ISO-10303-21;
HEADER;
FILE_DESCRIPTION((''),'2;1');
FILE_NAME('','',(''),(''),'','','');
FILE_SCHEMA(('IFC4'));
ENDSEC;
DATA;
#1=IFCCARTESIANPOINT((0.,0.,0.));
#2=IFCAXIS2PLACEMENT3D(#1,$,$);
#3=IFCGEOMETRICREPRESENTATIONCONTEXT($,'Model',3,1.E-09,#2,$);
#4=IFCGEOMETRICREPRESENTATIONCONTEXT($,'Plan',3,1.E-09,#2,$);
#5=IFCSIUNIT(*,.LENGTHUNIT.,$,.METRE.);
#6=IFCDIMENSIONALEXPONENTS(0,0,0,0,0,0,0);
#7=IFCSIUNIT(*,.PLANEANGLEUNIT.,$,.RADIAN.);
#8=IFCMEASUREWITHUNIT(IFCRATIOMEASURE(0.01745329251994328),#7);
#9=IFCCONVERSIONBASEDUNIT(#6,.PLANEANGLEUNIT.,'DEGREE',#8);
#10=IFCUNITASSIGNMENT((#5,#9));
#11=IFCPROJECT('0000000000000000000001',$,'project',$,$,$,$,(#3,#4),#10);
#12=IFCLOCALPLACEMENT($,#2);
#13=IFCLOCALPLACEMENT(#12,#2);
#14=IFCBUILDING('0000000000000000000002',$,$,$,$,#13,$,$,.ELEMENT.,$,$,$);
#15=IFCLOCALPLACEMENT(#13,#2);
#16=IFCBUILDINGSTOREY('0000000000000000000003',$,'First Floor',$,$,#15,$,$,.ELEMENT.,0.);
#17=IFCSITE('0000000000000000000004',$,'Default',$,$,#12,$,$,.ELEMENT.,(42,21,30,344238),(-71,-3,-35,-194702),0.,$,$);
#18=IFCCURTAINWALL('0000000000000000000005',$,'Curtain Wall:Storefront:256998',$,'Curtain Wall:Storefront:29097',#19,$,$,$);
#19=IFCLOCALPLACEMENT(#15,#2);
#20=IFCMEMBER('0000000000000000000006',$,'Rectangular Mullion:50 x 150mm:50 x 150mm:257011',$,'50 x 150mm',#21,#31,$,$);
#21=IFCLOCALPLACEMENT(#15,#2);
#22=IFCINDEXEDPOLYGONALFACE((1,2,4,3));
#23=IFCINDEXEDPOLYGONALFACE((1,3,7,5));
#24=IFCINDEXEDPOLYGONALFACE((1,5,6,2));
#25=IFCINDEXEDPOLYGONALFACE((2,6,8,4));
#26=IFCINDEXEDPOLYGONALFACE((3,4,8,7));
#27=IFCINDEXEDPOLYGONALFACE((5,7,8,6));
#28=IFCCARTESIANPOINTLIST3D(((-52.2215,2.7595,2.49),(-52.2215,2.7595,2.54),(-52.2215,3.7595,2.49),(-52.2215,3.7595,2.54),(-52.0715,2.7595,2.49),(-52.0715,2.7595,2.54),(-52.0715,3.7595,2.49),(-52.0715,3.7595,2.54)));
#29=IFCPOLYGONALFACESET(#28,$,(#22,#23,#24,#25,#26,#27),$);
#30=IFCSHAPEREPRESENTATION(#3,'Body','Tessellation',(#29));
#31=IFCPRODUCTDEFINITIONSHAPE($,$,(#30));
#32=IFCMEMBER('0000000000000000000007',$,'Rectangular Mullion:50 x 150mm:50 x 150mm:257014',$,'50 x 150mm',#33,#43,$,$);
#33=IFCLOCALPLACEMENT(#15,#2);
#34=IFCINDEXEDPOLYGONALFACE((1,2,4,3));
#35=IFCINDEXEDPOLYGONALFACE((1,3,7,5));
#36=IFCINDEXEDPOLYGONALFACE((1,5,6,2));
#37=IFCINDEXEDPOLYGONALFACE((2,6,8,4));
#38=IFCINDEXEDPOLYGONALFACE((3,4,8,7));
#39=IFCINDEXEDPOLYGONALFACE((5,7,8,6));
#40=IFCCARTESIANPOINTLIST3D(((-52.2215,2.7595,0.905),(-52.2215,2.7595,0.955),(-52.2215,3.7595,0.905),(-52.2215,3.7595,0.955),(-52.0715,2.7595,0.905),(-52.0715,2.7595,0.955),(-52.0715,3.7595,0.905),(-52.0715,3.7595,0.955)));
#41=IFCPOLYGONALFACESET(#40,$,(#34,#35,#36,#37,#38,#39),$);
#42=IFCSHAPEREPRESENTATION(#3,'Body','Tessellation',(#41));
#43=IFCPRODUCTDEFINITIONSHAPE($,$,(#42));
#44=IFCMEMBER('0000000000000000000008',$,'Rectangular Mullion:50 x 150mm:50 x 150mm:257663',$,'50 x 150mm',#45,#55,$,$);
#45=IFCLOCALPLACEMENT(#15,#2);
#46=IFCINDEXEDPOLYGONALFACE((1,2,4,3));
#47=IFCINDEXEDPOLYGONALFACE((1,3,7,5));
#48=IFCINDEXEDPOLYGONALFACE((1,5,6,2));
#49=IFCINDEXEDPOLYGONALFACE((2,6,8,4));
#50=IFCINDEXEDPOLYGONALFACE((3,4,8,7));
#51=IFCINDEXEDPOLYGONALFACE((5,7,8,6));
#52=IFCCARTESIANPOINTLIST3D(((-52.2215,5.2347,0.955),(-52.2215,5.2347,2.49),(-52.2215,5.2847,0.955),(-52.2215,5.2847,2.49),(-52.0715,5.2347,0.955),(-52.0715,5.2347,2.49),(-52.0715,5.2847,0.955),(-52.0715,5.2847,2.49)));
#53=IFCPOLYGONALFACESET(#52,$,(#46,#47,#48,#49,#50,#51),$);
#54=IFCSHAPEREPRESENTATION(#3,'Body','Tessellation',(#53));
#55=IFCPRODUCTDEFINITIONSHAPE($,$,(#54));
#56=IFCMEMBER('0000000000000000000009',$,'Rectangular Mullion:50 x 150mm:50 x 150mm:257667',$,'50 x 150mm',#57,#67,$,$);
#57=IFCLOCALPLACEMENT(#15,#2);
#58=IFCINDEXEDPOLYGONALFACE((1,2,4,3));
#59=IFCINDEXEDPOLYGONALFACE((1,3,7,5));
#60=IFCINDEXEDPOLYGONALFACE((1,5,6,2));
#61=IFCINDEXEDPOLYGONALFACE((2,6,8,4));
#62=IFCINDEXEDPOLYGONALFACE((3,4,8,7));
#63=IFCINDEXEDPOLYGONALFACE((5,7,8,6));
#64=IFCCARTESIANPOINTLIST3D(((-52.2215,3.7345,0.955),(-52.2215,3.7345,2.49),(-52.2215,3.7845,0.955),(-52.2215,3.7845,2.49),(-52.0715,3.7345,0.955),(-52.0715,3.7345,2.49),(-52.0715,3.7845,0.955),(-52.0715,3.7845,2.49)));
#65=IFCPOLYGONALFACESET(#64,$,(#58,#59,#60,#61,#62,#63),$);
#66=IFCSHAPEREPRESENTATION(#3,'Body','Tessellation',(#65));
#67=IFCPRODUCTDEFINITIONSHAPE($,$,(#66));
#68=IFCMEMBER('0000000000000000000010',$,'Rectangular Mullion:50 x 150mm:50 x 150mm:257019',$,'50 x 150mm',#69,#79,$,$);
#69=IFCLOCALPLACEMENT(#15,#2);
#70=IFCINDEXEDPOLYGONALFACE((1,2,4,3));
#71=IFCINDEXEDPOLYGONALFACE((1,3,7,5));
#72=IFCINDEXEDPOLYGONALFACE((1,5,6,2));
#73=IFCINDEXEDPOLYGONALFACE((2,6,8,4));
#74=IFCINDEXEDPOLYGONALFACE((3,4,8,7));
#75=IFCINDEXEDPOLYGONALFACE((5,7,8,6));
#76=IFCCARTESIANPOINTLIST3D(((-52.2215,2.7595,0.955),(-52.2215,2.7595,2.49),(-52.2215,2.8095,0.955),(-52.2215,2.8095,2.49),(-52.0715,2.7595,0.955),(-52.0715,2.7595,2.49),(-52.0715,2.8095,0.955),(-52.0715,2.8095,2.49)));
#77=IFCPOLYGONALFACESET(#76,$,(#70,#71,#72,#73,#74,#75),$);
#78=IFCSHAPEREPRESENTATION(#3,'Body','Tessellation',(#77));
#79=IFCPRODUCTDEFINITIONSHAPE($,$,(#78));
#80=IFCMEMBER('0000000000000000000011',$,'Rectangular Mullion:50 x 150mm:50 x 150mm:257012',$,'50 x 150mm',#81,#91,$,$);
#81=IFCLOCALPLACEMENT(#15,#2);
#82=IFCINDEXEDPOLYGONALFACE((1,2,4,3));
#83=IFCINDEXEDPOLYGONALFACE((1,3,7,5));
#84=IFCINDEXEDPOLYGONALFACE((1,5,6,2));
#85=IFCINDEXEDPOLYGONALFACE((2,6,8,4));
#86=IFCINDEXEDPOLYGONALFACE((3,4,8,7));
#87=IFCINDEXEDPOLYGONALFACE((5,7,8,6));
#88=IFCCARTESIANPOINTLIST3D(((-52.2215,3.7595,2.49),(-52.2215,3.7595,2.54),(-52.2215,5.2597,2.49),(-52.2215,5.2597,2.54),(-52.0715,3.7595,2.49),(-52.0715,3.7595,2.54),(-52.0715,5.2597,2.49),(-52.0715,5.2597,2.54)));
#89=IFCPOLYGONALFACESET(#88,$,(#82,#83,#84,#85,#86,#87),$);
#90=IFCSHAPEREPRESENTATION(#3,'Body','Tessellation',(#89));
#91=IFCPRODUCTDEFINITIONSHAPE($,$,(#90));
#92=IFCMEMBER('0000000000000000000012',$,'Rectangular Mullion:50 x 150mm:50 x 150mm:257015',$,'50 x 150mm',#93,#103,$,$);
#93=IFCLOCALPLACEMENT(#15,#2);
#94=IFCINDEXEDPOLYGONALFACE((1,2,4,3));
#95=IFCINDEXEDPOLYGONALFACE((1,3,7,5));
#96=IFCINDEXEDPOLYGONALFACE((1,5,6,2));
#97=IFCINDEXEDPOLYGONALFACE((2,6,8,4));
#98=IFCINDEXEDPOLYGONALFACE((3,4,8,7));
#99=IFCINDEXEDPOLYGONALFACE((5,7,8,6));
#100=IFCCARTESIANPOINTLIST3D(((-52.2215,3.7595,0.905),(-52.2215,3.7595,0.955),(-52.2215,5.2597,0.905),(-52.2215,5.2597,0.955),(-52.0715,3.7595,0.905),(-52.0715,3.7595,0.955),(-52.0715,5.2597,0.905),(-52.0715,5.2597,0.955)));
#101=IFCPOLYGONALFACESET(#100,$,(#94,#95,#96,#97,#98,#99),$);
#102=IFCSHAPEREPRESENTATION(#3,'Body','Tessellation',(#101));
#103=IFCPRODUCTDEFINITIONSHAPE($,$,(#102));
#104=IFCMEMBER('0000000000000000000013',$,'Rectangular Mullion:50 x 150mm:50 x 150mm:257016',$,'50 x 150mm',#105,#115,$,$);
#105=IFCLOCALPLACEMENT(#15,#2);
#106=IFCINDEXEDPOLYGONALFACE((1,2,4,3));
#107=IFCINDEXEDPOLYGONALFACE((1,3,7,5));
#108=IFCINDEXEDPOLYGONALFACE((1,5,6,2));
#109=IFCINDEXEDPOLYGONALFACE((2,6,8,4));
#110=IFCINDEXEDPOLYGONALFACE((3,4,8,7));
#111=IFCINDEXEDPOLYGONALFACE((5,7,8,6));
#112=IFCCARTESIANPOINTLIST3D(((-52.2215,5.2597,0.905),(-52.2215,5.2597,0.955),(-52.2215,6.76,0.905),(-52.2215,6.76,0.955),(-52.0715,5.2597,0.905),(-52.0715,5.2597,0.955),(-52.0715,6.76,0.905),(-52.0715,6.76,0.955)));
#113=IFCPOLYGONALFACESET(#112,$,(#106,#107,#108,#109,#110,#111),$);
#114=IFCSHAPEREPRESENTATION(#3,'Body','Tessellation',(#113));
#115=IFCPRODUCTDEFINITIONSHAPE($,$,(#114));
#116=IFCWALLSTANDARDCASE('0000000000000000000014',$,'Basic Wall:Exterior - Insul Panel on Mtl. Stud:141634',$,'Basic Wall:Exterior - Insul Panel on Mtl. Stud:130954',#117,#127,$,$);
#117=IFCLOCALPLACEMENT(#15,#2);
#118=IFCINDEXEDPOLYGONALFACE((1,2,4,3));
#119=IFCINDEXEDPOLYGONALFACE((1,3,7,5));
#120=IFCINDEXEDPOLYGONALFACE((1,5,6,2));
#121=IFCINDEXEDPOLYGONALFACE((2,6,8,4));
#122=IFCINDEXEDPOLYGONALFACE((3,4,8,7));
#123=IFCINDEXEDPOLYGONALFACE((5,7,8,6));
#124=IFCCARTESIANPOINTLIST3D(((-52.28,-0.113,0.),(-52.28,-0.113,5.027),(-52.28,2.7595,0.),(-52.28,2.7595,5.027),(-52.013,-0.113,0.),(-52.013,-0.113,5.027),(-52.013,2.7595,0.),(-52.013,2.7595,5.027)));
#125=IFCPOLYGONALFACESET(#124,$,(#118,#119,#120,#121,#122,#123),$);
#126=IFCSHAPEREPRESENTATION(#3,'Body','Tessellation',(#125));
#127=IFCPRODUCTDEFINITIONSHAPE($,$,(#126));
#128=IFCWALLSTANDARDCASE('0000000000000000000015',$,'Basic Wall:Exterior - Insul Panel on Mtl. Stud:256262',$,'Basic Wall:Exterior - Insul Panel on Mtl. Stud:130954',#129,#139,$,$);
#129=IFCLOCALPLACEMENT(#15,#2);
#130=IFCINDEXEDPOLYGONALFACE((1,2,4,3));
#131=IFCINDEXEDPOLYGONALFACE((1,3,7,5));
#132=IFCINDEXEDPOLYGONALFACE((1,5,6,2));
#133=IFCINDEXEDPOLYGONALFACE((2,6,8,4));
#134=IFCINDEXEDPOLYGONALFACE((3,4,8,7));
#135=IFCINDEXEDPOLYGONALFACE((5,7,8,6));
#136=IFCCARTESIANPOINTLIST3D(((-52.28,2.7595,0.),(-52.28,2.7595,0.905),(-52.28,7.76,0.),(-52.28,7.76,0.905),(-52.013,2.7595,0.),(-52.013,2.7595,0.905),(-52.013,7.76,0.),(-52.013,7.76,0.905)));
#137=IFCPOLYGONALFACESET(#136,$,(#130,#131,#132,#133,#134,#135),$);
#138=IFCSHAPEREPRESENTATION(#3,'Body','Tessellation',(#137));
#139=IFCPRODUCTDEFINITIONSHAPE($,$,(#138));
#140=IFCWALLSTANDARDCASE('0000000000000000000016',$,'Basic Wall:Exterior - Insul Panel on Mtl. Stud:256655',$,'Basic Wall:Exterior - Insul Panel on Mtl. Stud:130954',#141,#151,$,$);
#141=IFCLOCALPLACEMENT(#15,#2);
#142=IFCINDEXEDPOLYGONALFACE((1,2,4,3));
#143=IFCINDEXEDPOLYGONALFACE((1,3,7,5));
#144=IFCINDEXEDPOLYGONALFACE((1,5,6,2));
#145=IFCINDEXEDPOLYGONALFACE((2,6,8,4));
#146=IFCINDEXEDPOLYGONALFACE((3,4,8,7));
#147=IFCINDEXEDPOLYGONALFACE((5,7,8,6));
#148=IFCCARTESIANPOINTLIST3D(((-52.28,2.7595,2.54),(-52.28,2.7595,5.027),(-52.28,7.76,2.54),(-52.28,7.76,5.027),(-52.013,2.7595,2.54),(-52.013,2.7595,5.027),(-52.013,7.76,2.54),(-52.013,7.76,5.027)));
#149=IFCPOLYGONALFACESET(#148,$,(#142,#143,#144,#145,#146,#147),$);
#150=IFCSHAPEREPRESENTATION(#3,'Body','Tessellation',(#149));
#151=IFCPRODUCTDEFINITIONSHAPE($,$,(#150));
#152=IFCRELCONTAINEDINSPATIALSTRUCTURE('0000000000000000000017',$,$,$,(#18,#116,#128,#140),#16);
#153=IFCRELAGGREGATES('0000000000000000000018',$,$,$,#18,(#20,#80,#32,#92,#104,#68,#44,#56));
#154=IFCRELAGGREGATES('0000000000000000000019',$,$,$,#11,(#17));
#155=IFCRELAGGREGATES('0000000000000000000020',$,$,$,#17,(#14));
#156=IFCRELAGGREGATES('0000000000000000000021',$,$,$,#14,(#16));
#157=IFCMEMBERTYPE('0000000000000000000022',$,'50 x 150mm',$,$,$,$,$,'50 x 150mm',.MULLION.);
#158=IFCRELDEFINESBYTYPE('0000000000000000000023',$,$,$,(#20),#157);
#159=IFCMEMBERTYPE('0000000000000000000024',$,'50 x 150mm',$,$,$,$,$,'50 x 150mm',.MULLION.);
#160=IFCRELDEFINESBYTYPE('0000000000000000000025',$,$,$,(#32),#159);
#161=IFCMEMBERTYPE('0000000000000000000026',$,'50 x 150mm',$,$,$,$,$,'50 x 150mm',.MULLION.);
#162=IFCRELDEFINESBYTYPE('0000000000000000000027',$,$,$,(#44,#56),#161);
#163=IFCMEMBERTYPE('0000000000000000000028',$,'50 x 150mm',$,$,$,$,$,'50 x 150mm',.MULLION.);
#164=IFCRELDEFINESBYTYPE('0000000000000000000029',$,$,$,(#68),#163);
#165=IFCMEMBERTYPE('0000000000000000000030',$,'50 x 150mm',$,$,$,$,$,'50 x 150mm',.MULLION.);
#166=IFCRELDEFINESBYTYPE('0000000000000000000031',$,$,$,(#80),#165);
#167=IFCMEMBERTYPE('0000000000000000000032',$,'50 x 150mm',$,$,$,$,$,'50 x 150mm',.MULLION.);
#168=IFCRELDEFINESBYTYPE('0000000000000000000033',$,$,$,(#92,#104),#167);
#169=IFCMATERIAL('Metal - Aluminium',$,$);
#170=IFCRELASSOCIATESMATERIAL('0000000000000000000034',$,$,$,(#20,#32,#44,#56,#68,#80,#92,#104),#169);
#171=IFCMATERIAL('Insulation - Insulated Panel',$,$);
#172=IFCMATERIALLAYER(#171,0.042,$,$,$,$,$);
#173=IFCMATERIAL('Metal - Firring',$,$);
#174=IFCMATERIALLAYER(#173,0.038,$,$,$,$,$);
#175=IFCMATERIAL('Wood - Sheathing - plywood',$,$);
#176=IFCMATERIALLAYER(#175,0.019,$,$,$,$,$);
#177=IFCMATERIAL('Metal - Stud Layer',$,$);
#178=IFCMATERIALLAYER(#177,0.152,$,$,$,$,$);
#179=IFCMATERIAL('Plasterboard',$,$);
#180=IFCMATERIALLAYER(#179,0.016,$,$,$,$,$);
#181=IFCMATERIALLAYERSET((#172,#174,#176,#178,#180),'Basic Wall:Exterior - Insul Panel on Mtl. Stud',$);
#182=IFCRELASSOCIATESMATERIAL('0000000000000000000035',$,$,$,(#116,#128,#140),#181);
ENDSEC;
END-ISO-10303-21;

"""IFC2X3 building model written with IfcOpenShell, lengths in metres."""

from ifc_helpers import new_model, entity, si_unit, converted_unit, frame, frame_2d, origin, origin_2d_with_axis, place, context, project, spatial, rectangle, extrude, source, transform, mapped, material, layer, layer_set, layer_usage, type_object, type_shapes, element, aggregate, save


model = new_model("IFC2X3")

# Units and contexts
model_context = context("Model", 3, precision=1e-09, world=origin())
plan_context = context("Plan", 3, precision=1e-09, world=origin())
ifc_project = project(units=[si_unit("LENGTHUNIT", "METRE"), converted_unit("PLANEANGLEUNIT", "DEGREE", entity("IfcRatioMeasure", 0.01745329251994328), si_unit("PLANEANGLEUNIT", "RADIAN"), dimensions=[0, 0, 0, 0, 0, 0, 0])], contexts=[model_context, plan_context])

# Site, building, storey
site_placement = place(None, origin())
site = spatial("IfcSite", under=ifc_project, at=site_placement, Name="Default", CompositionType="ELEMENT", RefLatitude=(42, 21, 30, 344238), RefLongitude=(-71, -3, -35, -194702), RefElevation=0.0)
building_placement = place(site_placement, origin())
building = spatial("IfcBuilding", under=site, at=building_placement, CompositionType="ELEMENT")
storey_placement = place(building_placement, origin())
storey = spatial("IfcBuildingStorey", under=building, at=storey_placement, Name="First Floor", CompositionType="ELEMENT", Elevation=0.0)

# Curtain wall, members
curtain_wall_placement = place(storey_placement, origin())
curtain_wall = element("IfcCurtainWall", 1, at=curtain_wall_placement, inside=storey, Name="Curtain Wall:Storefront:256998", ObjectType="Curtain Wall:Storefront:29097")
ifc_material_1 = material(Name="Metal - Aluminium")
member_type_1 = type_object("IfcMemberType", Name="50 x 150mm", ElementType="50 x 150mm", PredefinedType="MULLION")
shared_shape_1 = source(origin(), model_context, "Body", "SweptSolid", [
    extrude(rectangle(XDim=0.05, YDim=0.15, at=origin_2d_with_axis()), frame((-0.025, 0.0, -1.0), z_axis=(0.0, 0.0, 1.0), x_axis=(-1.0, 0.0, 0.0)), (0.0, 0.0, 1.0), 1.0),
])
type_shapes(member_type_1, [shared_shape_1])
member_1_placement = place(storey_placement, frame((-52.1465, 3.7595, 2.54), z_axis=(0.0, 1.0, 0.0), x_axis=(0.0, 0.0, 1.0)))
member_1 = element("IfcMember", 2, at=member_1_placement, type_object=member_type_1, material=ifc_material_1, Name="Rectangular Mullion:50 x 150mm:50 x 150mm:257011", ObjectType="50 x 150mm", context=model_context, shape_type="MappedRepresentation", body=[
    mapped(shared_shape_1, transform((0.0, 0.0, 0.0), scale=1.0)),
])
member_type_2 = type_object("IfcMemberType", Name="50 x 150mm", ElementType="50 x 150mm", PredefinedType="MULLION")
type_shapes(member_type_2, [shared_shape_1])
member_2_placement = place(storey_placement, frame((-52.1465, 2.7595, 0.905), z_axis=(0.0, -1.0, 0.0), x_axis=(0.0, 0.0, -1.0)))
member_2 = element("IfcMember", 3, at=member_2_placement, type_object=member_type_2, material=ifc_material_1, Name="Rectangular Mullion:50 x 150mm:50 x 150mm:257014", ObjectType="50 x 150mm", context=model_context, shape_type="MappedRepresentation", body=[
    mapped(shared_shape_1, transform((0.0, 0.0, 0.0), scale=1.0)),
])
member_type_3 = type_object("IfcMemberType", Name="50 x 150mm", ElementType="50 x 150mm", PredefinedType="MULLION")
shared_shape_2 = source(origin(), model_context, "Body", "SweptSolid", [
    extrude(rectangle(XDim=0.05, YDim=0.15, at=origin_2d_with_axis()), frame((0.0, 0.0, -1.535), z_axis=(0.0, 0.0, 1.0), x_axis=(-1.0, 0.0, 0.0)), (0.0, 0.0, 1.0), 1.535),
])
type_shapes(member_type_3, [shared_shape_2])
member_3_placement = place(storey_placement, frame((-52.1465, 5.2597, 0.955), z_axis=(0.0, 0.0, -1.0), x_axis=(0.0, 1.0, 0.0)))
member_3 = element("IfcMember", 4, at=member_3_placement, type_object=member_type_3, material=ifc_material_1, Name="Rectangular Mullion:50 x 150mm:50 x 150mm:257663", ObjectType="50 x 150mm", context=model_context, shape_type="MappedRepresentation", body=[
    mapped(shared_shape_2, transform((0.0, 0.0, 0.0), scale=1.0)),
])
member_4_placement = place(storey_placement, frame((-52.1465, 3.7595, 0.955), z_axis=(0.0, 0.0, -1.0), x_axis=(0.0, 1.0, 0.0)))
member_4 = element("IfcMember", 5, at=member_4_placement, type_object=member_type_3, material=ifc_material_1, Name="Rectangular Mullion:50 x 150mm:50 x 150mm:257667", ObjectType="50 x 150mm", context=model_context, shape_type="MappedRepresentation", body=[
    mapped(shared_shape_2, transform((0.0, 0.0, 0.0), scale=1.0)),
])
member_type_4 = type_object("IfcMemberType", Name="50 x 150mm", ElementType="50 x 150mm", PredefinedType="MULLION")
shared_shape_3 = source(origin(), model_context, "Body", "SweptSolid", [
    extrude(rectangle(XDim=0.05, YDim=0.15, at=origin_2d_with_axis()), frame((-0.025, 0.0, -1.535), z_axis=(0.0, 0.0, 1.0), x_axis=(-1.0, 0.0, 0.0)), (0.0, 0.0, 1.0), 1.535),
])
type_shapes(member_type_4, [shared_shape_3])
member_5_placement = place(storey_placement, frame((-52.1465, 2.7595, 2.49), z_axis=(0.0, 0.0, 1.0), x_axis=(0.0, -1.0, 0.0)))
member_5 = element("IfcMember", 6, at=member_5_placement, type_object=member_type_4, material=ifc_material_1, Name="Rectangular Mullion:50 x 150mm:50 x 150mm:257019", ObjectType="50 x 150mm", context=model_context, shape_type="MappedRepresentation", body=[
    mapped(shared_shape_3, transform((0.0, 0.0, 0.0), scale=1.0)),
])
member_type_5 = type_object("IfcMemberType", Name="50 x 150mm", ElementType="50 x 150mm", PredefinedType="MULLION")
shared_shape_4 = source(origin(), model_context, "Body", "SweptSolid", [
    extrude(rectangle(XDim=0.05, YDim=0.15, at=origin_2d_with_axis()), frame((-0.025, 0.0, -1.5003), z_axis=(0.0, 0.0, 1.0), x_axis=(-1.0, 0.0, 0.0)), (0.0, 0.0, 1.0), 1.5003),
])
type_shapes(member_type_5, [shared_shape_4])
member_6_placement = place(storey_placement, frame((-52.1465, 5.2597, 2.54), z_axis=(0.0, 1.0, 0.0), x_axis=(0.0, 0.0, 1.0)))
member_6 = element("IfcMember", 7, at=member_6_placement, type_object=member_type_5, material=ifc_material_1, Name="Rectangular Mullion:50 x 150mm:50 x 150mm:257012", ObjectType="50 x 150mm", context=model_context, shape_type="MappedRepresentation", body=[
    mapped(shared_shape_4, transform((0.0, 0.0, 0.0), scale=1.0)),
])
member_type_6 = type_object("IfcMemberType", Name="50 x 150mm", ElementType="50 x 150mm", PredefinedType="MULLION")
shared_shape_5 = source(origin(), model_context, "Body", "SweptSolid", [
    extrude(rectangle(XDim=0.05, YDim=0.15, at=origin_2d_with_axis()), frame((-0.025, 0.0, -1.5003), z_axis=(0.0, 0.0, 1.0), x_axis=(-1.0, 0.0, 0.0)), (0.0, 0.0, 1.0), 1.5003),
])
type_shapes(member_type_6, [shared_shape_5])
member_7_placement = place(storey_placement, frame((-52.1465, 3.7595, 0.905), z_axis=(0.0, -1.0, 0.0), x_axis=(0.0, 0.0, -1.0)))
member_7 = element("IfcMember", 8, at=member_7_placement, type_object=member_type_6, material=ifc_material_1, Name="Rectangular Mullion:50 x 150mm:50 x 150mm:257015", ObjectType="50 x 150mm", context=model_context, shape_type="MappedRepresentation", body=[
    mapped(shared_shape_5, transform((0.0, 0.0, 0.0), scale=1.0)),
])
member_8_placement = place(storey_placement, frame((-52.1465, 5.2597, 0.905), z_axis=(0.0, -1.0, 0.0), x_axis=(0.0, 0.0, -1.0)))
member_8 = element("IfcMember", 9, at=member_8_placement, type_object=member_type_6, material=ifc_material_1, Name="Rectangular Mullion:50 x 150mm:50 x 150mm:257016", ObjectType="50 x 150mm", context=model_context, shape_type="MappedRepresentation", body=[
    mapped(shared_shape_5, transform((0.0, 0.0, 0.0), scale=1.0)),
])
aggregate(curtain_wall, [member_1, member_6, member_2, member_7, member_8, member_5, member_3, member_4])

# Walls
ifc_material_2 = material(Name="Insulation - Insulated Panel")
ifc_layer_1 = layer(ifc_material_2, 0.042)
ifc_material_3 = material(Name="Metal - Firring")
ifc_layer_2 = layer(ifc_material_3, 0.038)
ifc_material_4 = material(Name="Wood - Sheathing - plywood")
ifc_layer_3 = layer(ifc_material_4, 0.019)
ifc_material_5 = material(Name="Metal - Stud Layer")
ifc_layer_4 = layer(ifc_material_5, 0.152)
ifc_material_6 = material(Name="Plasterboard")
ifc_layer_5 = layer(ifc_material_6, 0.016)
ifc_layer_set = layer_set([ifc_layer_1, ifc_layer_2, ifc_layer_3, ifc_layer_4, ifc_layer_5], Name="Basic Wall:Exterior - Insul Panel on Mtl. Stud")
ifc_layer_usage = layer_usage(ifc_layer_set, "AXIS2", "NEGATIVE", 0.1335)
wall_1_placement = place(storey_placement, frame((-52.1465, -0.113, 0.0), z_axis=(0.0, 0.0, 1.0), x_axis=(0.0, 1.0, 0.0)))
element("IfcWallStandardCase", 10, at=wall_1_placement, inside=storey, material=ifc_layer_usage, Name="Basic Wall:Exterior - Insul Panel on Mtl. Stud:141634", ObjectType="Basic Wall:Exterior - Insul Panel on Mtl. Stud:130954", context=model_context, shape_type="SweptSolid", body=[
    extrude(rectangle(XDim=2.8725, YDim=0.267, at=frame_2d((1.4362, 0.0), x_axis=(-1.0, 0.0))), origin(), (0.0, 0.0, 1.0), 5.027),
])
wall_2_placement = place(storey_placement, frame((-52.1465, 2.7595, 0.0), z_axis=(0.0, 0.0, 1.0), x_axis=(0.0, 1.0, 0.0)))
element("IfcWallStandardCase", 11, at=wall_2_placement, inside=storey, material=ifc_layer_usage, Name="Basic Wall:Exterior - Insul Panel on Mtl. Stud:256262", ObjectType="Basic Wall:Exterior - Insul Panel on Mtl. Stud:130954", context=model_context, shape_type="SweptSolid", body=[
    extrude(rectangle(XDim=5.0005, YDim=0.267, at=frame_2d((2.5003, 0.0), x_axis=(-1.0, 0.0))), origin(), (0.0, 0.0, 1.0), 0.905),
])
wall_3_placement = place(storey_placement, frame((-52.1465, 2.7595, 2.54), z_axis=(0.0, 0.0, 1.0), x_axis=(0.0, 1.0, 0.0)))
element("IfcWallStandardCase", 12, at=wall_3_placement, inside=storey, material=ifc_layer_usage, Name="Basic Wall:Exterior - Insul Panel on Mtl. Stud:256655", ObjectType="Basic Wall:Exterior - Insul Panel on Mtl. Stud:130954", context=model_context, shape_type="SweptSolid", body=[
    extrude(rectangle(XDim=5.0005, YDim=0.267, at=frame_2d((2.5003, 0.0), x_axis=(-1.0, 0.0))), origin(), (0.0, 0.0, 1.0), 2.487),
])

save(model, "model.ifc")
